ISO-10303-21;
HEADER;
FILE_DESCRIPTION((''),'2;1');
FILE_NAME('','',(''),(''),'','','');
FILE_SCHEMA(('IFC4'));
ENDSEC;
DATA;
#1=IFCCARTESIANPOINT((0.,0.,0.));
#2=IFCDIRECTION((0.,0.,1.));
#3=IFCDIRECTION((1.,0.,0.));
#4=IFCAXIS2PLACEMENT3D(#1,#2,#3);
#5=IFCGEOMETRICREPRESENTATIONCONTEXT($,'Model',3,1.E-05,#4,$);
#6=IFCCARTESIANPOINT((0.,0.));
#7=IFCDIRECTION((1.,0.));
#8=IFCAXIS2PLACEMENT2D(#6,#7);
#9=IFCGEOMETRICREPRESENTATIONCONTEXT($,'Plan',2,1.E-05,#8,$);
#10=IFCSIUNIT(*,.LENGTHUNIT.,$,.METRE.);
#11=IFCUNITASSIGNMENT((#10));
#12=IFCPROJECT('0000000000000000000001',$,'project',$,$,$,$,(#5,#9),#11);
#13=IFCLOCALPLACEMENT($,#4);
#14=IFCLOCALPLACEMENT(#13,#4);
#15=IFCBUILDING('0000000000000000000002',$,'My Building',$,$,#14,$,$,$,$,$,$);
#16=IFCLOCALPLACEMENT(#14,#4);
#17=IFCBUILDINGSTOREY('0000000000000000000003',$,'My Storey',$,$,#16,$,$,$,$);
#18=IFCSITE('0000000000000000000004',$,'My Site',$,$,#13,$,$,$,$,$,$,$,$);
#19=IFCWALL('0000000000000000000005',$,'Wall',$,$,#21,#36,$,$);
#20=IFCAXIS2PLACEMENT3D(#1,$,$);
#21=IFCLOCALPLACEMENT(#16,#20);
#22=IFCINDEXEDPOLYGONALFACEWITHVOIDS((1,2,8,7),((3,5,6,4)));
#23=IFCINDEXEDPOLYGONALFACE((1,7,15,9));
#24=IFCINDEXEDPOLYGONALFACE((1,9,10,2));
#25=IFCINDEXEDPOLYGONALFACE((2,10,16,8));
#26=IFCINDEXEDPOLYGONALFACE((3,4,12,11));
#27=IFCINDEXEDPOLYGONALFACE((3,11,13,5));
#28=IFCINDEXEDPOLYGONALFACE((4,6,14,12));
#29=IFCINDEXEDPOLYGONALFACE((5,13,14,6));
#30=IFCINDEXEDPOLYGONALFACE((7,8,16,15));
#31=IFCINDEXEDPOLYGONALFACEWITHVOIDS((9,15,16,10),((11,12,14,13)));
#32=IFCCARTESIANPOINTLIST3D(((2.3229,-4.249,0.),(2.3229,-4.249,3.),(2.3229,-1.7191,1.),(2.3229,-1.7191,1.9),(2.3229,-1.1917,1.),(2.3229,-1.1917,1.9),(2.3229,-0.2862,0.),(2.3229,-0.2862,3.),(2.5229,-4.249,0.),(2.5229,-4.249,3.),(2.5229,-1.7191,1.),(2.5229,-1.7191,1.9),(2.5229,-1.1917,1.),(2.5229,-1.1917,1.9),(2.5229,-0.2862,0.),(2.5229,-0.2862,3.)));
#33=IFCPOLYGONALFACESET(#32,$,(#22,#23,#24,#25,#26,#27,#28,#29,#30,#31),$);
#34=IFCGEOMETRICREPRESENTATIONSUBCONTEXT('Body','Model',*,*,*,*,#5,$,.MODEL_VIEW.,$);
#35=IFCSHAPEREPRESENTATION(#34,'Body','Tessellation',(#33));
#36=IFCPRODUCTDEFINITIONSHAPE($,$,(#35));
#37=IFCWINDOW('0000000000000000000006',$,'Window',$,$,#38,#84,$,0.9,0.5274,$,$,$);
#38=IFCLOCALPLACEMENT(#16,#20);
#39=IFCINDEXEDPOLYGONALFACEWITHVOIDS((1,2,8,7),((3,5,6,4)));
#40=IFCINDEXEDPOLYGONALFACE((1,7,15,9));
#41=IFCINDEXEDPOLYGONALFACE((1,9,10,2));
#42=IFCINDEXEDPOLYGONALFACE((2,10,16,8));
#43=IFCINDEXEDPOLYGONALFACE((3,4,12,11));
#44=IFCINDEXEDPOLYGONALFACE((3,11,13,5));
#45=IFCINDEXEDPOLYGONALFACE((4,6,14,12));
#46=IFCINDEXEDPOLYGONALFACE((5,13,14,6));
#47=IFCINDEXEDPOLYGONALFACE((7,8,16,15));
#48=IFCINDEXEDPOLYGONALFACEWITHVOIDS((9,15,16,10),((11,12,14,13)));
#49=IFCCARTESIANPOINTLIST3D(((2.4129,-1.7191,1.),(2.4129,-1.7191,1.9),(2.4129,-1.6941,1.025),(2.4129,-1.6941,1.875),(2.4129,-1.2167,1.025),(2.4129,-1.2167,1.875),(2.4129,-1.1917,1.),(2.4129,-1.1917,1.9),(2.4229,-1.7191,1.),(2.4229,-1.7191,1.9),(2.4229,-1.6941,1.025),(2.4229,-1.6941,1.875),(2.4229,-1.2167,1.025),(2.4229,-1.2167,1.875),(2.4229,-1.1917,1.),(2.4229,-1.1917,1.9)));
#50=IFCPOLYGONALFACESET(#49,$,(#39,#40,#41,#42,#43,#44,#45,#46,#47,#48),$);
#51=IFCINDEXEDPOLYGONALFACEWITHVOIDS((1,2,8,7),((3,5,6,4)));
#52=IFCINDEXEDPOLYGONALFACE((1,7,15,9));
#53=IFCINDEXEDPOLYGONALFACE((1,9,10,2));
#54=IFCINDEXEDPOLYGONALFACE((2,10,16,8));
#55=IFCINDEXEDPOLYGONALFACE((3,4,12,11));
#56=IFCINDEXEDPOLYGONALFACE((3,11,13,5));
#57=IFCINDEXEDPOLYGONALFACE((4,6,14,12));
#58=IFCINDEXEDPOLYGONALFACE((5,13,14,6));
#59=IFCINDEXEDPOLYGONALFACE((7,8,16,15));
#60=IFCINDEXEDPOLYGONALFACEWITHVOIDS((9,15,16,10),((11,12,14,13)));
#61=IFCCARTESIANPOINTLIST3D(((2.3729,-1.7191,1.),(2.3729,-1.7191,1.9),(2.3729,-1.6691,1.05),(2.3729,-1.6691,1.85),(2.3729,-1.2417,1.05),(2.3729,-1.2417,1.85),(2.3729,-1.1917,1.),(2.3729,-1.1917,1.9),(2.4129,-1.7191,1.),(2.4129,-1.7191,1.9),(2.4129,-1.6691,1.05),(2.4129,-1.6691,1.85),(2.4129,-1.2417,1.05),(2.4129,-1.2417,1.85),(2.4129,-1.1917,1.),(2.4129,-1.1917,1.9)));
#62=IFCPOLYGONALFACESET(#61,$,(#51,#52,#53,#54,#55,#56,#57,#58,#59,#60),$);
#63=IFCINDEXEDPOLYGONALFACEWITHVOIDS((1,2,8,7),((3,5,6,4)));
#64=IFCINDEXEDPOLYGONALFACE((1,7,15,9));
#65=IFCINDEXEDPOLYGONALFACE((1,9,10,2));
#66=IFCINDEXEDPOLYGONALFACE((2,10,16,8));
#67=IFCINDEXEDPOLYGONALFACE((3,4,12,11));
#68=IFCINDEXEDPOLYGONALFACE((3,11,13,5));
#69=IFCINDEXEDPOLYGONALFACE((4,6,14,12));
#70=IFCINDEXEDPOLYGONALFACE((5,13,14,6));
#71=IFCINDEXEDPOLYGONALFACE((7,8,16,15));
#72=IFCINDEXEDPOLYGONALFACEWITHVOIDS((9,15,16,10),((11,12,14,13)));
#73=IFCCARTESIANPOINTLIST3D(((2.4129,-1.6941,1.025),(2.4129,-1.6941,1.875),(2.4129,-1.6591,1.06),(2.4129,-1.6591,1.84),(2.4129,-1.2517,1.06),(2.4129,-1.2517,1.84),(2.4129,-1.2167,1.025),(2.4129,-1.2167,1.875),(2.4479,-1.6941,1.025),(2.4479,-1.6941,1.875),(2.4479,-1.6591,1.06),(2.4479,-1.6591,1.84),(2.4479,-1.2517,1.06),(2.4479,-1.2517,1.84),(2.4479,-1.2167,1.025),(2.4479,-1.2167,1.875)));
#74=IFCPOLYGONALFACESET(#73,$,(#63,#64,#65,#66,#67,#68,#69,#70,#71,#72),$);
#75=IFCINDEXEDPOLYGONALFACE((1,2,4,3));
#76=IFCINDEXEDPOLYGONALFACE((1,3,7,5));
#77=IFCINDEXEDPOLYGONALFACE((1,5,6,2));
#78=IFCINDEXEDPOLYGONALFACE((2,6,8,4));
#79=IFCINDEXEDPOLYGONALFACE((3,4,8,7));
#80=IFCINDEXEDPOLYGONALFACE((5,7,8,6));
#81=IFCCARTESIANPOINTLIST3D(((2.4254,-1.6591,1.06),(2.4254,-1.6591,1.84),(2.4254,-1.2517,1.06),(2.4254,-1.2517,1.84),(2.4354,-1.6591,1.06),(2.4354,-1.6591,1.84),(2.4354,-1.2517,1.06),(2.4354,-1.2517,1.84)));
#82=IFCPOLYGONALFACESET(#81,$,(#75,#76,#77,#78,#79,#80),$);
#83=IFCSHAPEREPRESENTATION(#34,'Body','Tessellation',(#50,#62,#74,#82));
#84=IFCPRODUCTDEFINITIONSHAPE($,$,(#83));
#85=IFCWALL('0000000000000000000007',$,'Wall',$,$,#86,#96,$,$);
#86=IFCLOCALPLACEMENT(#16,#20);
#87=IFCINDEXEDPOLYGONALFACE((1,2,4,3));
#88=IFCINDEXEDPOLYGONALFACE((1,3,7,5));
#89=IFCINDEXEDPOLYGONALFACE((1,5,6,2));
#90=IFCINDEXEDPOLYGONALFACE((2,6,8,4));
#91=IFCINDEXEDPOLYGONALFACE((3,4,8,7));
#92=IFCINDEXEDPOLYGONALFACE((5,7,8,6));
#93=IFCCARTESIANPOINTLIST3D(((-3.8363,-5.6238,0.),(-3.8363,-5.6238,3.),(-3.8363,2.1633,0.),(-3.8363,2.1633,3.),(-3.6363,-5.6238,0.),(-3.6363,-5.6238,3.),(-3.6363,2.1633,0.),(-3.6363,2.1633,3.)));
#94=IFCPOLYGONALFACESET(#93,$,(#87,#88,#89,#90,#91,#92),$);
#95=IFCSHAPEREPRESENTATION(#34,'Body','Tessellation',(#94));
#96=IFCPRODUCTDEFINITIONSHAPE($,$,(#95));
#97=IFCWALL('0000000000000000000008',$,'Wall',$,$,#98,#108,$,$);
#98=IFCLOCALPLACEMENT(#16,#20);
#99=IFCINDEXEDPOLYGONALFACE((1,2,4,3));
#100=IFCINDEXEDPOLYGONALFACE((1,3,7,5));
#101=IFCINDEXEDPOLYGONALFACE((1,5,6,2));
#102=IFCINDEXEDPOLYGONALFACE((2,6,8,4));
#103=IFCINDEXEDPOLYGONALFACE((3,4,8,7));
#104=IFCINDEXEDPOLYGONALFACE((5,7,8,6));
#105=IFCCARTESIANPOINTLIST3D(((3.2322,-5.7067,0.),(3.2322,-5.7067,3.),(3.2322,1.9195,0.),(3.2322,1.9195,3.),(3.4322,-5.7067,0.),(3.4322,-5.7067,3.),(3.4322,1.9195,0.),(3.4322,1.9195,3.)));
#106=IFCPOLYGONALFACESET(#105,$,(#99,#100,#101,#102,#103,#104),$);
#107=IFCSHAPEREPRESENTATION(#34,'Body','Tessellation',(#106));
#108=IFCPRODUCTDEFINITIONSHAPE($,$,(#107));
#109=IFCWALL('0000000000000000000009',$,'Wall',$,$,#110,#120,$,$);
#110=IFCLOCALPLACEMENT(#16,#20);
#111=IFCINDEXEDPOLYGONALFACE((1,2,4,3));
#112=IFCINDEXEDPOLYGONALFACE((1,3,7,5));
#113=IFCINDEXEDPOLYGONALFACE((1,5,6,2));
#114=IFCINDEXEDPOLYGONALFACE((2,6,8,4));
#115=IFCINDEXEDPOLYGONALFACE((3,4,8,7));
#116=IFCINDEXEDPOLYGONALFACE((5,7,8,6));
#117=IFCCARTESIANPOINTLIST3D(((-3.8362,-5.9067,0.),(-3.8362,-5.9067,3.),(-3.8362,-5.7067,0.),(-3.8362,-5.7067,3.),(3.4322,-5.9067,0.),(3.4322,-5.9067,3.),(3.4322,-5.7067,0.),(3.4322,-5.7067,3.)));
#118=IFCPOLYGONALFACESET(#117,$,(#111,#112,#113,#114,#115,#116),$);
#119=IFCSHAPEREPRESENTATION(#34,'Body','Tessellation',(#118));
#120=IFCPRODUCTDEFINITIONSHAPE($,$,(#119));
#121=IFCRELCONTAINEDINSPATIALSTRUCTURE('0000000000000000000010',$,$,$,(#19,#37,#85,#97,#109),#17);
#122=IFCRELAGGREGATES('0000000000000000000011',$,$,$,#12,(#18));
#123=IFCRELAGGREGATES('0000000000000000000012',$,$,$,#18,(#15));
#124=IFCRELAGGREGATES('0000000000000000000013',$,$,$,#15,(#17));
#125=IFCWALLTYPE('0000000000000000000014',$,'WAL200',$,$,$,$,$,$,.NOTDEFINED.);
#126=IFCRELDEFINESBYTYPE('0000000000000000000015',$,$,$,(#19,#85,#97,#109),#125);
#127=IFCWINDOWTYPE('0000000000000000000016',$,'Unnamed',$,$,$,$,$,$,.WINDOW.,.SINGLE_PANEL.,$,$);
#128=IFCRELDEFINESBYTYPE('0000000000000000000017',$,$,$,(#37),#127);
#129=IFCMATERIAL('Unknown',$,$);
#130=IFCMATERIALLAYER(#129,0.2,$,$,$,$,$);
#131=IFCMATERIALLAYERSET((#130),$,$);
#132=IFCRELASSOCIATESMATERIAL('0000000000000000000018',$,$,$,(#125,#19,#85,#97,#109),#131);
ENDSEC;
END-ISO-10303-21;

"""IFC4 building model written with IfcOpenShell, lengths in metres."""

from ifc_helpers import new_model, entity, si_unit, frame, origin_with_axes, origin_2d_with_axis, place, context, subcontext, project, spatial, line, indexed_curve, outline, extrude, shape, source, transform, mapped, material, layer, layer_set, layer_usage, type_object, type_shapes, element, fill, save


model = new_model("IFC4")

# Units and contexts
model_context = context("Model", 3, precision=1e-05, world=origin_with_axes())
plan_context = context("Plan", 2, precision=1e-05, world=origin_2d_with_axis())
body_context_1 = subcontext(model_context, "Body", "Model", "MODEL_VIEW")
body_context_2 = subcontext(plan_context, "Body", "Plan", "PLAN_VIEW")
ifc_project = project(units=[si_unit("LENGTHUNIT", "METRE")], contexts=[model_context, plan_context])

# Site, building, storey
site_placement = place(None, origin_with_axes())
site = spatial("IfcSite", under=ifc_project, at=site_placement, Name="My Site")
building_placement = place(site_placement, origin_with_axes())
building = spatial("IfcBuilding", under=site, at=building_placement, Name="My Building")
storey_placement = place(building_placement, origin_with_axes())
storey = spatial("IfcBuildingStorey", under=building, at=storey_placement, Name="My Storey")

# Shared definitions
ifc_material = material(Name="Unknown")

# Shared definitions
ifc_layer_1 = layer(ifc_material, 0.2)
ifc_layer_set_1 = layer_set([ifc_layer_1])
wall_type_1 = type_object("IfcWallType", Name="WAL200", PredefinedType="NOTDEFINED", material=ifc_layer_set_1)
shared_shape_1 = source(origin_with_axes(), body_context_1, "Body", "SweptSolid", [
    extrude(outline(indexed_curve([(0.0, 0.0), (0.5274, 0.0), (0.5274, 0.9), (0.0, 0.9)], segments=[line(1, 2, 3, 4, 1)])), frame((0.0, -0.6, 0.0), z_axis=(0.0, -1.0, 0.0), x_axis=(1.0, 0.0, 0.0)), (0.0, 0.0, -1.0), 1.2),
])
window_type_1 = type_object("IfcWindowType", Name="Unnamed", PartitioningType="SINGLE_PANEL", PredefinedType="WINDOW")
shared_shape_2 = source(origin_with_axes(), body_context_1, "Body", "SweptSolid", [
    extrude(outline(indexed_curve([(0.0, 0.0), (0.5274, 0.0), (0.5274, 0.9), (0.0, 0.9)], segments=[line(1, 2, 3, 4, 1)]), holes=[indexed_curve([(0.025, 0.025), (0.5024, 0.025), (0.5024, 0.875), (0.025, 0.875)], segments=[line(1, 2, 3, 4, 1)])]), frame((0.0, 0.09, 0.0), z_axis=(0.0, -1.0, 0.0), x_axis=(1.0, 0.0, 0.0)), (0.0, 0.0, -1.0), 0.01),
    extrude(outline(indexed_curve([(0.0, 0.0), (0.5274, 0.0), (0.5274, 0.9), (0.0, 0.9)], segments=[line(1, 2, 3, 4, 1)]), holes=[indexed_curve([(0.05, 0.05), (0.4774, 0.05), (0.4774, 0.85), (0.05, 0.85)], segments=[line(1, 2, 3, 4, 1)])]), frame((0.0, 0.05, 0.0), z_axis=(0.0, -1.0, 0.0), x_axis=(1.0, 0.0, 0.0)), (0.0, 0.0, -1.0), 0.04),
    extrude(outline(indexed_curve([(0.0, 0.0), (0.4774, 0.0), (0.4774, 0.85), (0.0, 0.85)], segments=[line(1, 2, 3, 4, 1)]), holes=[indexed_curve([(0.035, 0.035), (0.4424, 0.035), (0.4424, 0.815), (0.035, 0.815)], segments=[line(1, 2, 3, 4, 1)])]), frame((0.025, 0.09, 0.025), z_axis=(0.0, -1.0, 0.0), x_axis=(1.0, 0.0, 0.0)), (0.0, 0.0, -1.0), 0.035),
    extrude(outline(indexed_curve([(0.035, 0.035), (0.4424, 0.035), (0.4424, 0.815), (0.035, 0.815)], segments=[line(1, 2, 3, 4, 1)])), frame((0.025, 0.1025, 0.025), z_axis=(0.0, -1.0, 0.0), x_axis=(1.0, 0.0, 0.0)), (0.0, 0.0, -1.0), 0.01),
])
shared_shape_3 = source(origin_with_axes(), body_context_2, "Body", "Curve2D", [
    entity("IfcIndexedPolyCurve", entity("IfcCartesianPointList2D", [[0.05, 0.05], [0.4774, 0.05]])),
    entity("IfcIndexedPolyCurve", entity("IfcCartesianPointList2D", [[0.0, 0.1], [0.025, 0.1], [0.025, 0.09], [0.05, 0.09], [0.05, 0.05], [0.0, 0.05]]), [entity("IfcLineIndex", [1, 2, 3, 4, 5, 6, 1])]),
    entity("IfcIndexedPolyCurve", entity("IfcCartesianPointList2D", [[0.5274, 0.1], [0.5024, 0.1], [0.5024, 0.09], [0.4774, 0.09], [0.4774, 0.05], [0.5274, 0.05]]), [entity("IfcLineIndex", [1, 2, 3, 4, 5, 6, 1])]),
    entity("IfcIndexedPolyCurve", entity("IfcCartesianPointList2D", [[0.025, 0.09], [0.06, 0.09], [0.06, 0.125], [0.025, 0.125]]), [entity("IfcLineIndex", [1, 2, 3, 4, 1])]),
    entity("IfcIndexedPolyCurve", entity("IfcCartesianPointList2D", [[0.5024, 0.09], [0.4674, 0.09], [0.4674, 0.125], [0.5024, 0.125]]), [entity("IfcLineIndex", [1, 2, 3, 4, 1])]),
    entity("IfcIndexedPolyCurve", entity("IfcCartesianPointList2D", [[0.06, 0.09], [0.4674, 0.09]])),
    entity("IfcIndexedPolyCurve", entity("IfcCartesianPointList2D", [[0.06, 0.125], [0.4674, 0.125]])),
    entity("IfcIndexedPolyCurve", entity("IfcCartesianPointList2D", [[0.06, 0.1075], [0.4674, 0.1075]])),
])
type_shapes(window_type_1, [shared_shape_2, shared_shape_3])

# Wall, opening, window
ifc_layer_usage_1 = layer_usage(ifc_layer_set_1, "AXIS2", "POSITIVE", 0.0)
wall_1_placement = place(storey_placement, frame((2.5229, -4.249, 0.0), z_axis=(0.0, 0.0, 1.0), x_axis=(0.0, 1.0, 0.0)))
wall_1 = element("IfcWall", 1, at=wall_1_placement, inside=storey, type_object=wall_type_1, material=ifc_layer_usage_1, Name="Wall", context=body_context_1, shape_type="SweptSolid", body=[
    extrude(outline(indexed_curve([(0.0, 0.0), (0.0, 0.2), (3.9628, 0.2), (3.9628, 0.0)], segments=[line(1, 2, 3, 4, 1)])), origin_with_axes(), (0.0, 0.0, 1.0), 3.0),
])
opening_1_placement = place(wall_1_placement, frame((3.0573, 0.2, 1.0), z_axis=(0.0, 0.0, 1.0), x_axis=(-1.0, 0.0, 0.0)))
opening_1 = element("IfcOpeningElement", 2, at=opening_1_placement, cuts=wall_1, PredefinedType="OPENING", context=body_context_1, shape_type="MappedRepresentation", body=[
    mapped(shared_shape_1, transform((0.0, 0.0, 0.0), x_axis=(1.0, 0.0, 0.0), y_axis=(0.0, 1.0, 0.0), z_axis=(0.0, 0.0, 1.0), scale=1.0)),
])
window_1_placement = place(opening_1_placement, origin_with_axes())
window_1 = element("IfcWindow", 3, at=window_1_placement, inside=storey, type_object=window_type_1, Name="Window", OverallHeight=0.9, OverallWidth=0.5274, shapes=[
    shape(body_context_1, "Body", "MappedRepresentation", [mapped(shared_shape_2, transform((0.0, 0.0, 0.0), x_axis=(1.0, 0.0, 0.0), y_axis=(0.0, 1.0, 0.0), z_axis=(0.0, 0.0, 1.0), scale=1.0))]),
    shape(body_context_2, "Body", "MappedRepresentation", [mapped(shared_shape_3, transform((0.0, 0.0, 0.0), x_axis=(1.0, 0.0, 0.0), y_axis=(0.0, 1.0, 0.0), z_axis=(0.0, 0.0, 1.0), scale=1.0))]),
])
fill(opening_1, window_1)

# Walls
ifc_layer_usage_2 = layer_usage(ifc_layer_set_1, "AXIS2", "POSITIVE", 0.0)
wall_2_placement = place(storey_placement, frame((-3.6363, -5.6238, 0.0), z_axis=(0.0, 0.0, 1.0), x_axis=(0.0, 1.0, 0.0)))
element("IfcWall", 4, at=wall_2_placement, inside=storey, type_object=wall_type_1, material=ifc_layer_usage_2, Name="Wall", context=body_context_1, shape_type="SweptSolid", body=[
    extrude(outline(indexed_curve([(0.0, 0.0), (0.0, 0.2), (7.7871, 0.2), (7.7871, 0.0)], segments=[line(1, 2, 3, 4, 1)])), origin_with_axes(), (0.0, 0.0, 1.0), 3.0),
])
ifc_layer_usage_3 = layer_usage(ifc_layer_set_1, "AXIS2", "POSITIVE", 0.0)
wall_3_placement = place(storey_placement, frame((3.4322, -5.7067, 0.0), z_axis=(0.0, 0.0, 1.0), x_axis=(0.0, 1.0, 0.0)))
element("IfcWall", 5, at=wall_3_placement, inside=storey, type_object=wall_type_1, material=ifc_layer_usage_3, Name="Wall", context=body_context_1, shape_type="SweptSolid", body=[
    extrude(outline(indexed_curve([(0.0, 0.0), (0.0, 0.2), (7.6262, 0.2), (7.6262, 0.0)], segments=[line(1, 2, 3, 4, 1)])), origin_with_axes(), (0.0, 0.0, 1.0), 3.0),
])
ifc_layer_usage_4 = layer_usage(ifc_layer_set_1, "AXIS2", "POSITIVE", 0.0)
wall_4_placement = place(storey_placement, frame((3.4322, -5.7067, 0.0), z_axis=(0.0, 0.0, 1.0), x_axis=(-1.0, 0.0, 0.0)))
element("IfcWall", 6, at=wall_4_placement, inside=storey, type_object=wall_type_1, material=ifc_layer_usage_4, Name="Wall", context=body_context_1, shape_type="SweptSolid", body=[
    extrude(outline(indexed_curve([(0.0, 0.0), (0.0, 0.2), (7.2684, 0.2), (7.2684, 0.0)], segments=[line(1, 2, 3, 4, 1)])), origin_with_axes(), (0.0, 0.0, 1.0), 3.0),
])

save(model, "model.ifc")
